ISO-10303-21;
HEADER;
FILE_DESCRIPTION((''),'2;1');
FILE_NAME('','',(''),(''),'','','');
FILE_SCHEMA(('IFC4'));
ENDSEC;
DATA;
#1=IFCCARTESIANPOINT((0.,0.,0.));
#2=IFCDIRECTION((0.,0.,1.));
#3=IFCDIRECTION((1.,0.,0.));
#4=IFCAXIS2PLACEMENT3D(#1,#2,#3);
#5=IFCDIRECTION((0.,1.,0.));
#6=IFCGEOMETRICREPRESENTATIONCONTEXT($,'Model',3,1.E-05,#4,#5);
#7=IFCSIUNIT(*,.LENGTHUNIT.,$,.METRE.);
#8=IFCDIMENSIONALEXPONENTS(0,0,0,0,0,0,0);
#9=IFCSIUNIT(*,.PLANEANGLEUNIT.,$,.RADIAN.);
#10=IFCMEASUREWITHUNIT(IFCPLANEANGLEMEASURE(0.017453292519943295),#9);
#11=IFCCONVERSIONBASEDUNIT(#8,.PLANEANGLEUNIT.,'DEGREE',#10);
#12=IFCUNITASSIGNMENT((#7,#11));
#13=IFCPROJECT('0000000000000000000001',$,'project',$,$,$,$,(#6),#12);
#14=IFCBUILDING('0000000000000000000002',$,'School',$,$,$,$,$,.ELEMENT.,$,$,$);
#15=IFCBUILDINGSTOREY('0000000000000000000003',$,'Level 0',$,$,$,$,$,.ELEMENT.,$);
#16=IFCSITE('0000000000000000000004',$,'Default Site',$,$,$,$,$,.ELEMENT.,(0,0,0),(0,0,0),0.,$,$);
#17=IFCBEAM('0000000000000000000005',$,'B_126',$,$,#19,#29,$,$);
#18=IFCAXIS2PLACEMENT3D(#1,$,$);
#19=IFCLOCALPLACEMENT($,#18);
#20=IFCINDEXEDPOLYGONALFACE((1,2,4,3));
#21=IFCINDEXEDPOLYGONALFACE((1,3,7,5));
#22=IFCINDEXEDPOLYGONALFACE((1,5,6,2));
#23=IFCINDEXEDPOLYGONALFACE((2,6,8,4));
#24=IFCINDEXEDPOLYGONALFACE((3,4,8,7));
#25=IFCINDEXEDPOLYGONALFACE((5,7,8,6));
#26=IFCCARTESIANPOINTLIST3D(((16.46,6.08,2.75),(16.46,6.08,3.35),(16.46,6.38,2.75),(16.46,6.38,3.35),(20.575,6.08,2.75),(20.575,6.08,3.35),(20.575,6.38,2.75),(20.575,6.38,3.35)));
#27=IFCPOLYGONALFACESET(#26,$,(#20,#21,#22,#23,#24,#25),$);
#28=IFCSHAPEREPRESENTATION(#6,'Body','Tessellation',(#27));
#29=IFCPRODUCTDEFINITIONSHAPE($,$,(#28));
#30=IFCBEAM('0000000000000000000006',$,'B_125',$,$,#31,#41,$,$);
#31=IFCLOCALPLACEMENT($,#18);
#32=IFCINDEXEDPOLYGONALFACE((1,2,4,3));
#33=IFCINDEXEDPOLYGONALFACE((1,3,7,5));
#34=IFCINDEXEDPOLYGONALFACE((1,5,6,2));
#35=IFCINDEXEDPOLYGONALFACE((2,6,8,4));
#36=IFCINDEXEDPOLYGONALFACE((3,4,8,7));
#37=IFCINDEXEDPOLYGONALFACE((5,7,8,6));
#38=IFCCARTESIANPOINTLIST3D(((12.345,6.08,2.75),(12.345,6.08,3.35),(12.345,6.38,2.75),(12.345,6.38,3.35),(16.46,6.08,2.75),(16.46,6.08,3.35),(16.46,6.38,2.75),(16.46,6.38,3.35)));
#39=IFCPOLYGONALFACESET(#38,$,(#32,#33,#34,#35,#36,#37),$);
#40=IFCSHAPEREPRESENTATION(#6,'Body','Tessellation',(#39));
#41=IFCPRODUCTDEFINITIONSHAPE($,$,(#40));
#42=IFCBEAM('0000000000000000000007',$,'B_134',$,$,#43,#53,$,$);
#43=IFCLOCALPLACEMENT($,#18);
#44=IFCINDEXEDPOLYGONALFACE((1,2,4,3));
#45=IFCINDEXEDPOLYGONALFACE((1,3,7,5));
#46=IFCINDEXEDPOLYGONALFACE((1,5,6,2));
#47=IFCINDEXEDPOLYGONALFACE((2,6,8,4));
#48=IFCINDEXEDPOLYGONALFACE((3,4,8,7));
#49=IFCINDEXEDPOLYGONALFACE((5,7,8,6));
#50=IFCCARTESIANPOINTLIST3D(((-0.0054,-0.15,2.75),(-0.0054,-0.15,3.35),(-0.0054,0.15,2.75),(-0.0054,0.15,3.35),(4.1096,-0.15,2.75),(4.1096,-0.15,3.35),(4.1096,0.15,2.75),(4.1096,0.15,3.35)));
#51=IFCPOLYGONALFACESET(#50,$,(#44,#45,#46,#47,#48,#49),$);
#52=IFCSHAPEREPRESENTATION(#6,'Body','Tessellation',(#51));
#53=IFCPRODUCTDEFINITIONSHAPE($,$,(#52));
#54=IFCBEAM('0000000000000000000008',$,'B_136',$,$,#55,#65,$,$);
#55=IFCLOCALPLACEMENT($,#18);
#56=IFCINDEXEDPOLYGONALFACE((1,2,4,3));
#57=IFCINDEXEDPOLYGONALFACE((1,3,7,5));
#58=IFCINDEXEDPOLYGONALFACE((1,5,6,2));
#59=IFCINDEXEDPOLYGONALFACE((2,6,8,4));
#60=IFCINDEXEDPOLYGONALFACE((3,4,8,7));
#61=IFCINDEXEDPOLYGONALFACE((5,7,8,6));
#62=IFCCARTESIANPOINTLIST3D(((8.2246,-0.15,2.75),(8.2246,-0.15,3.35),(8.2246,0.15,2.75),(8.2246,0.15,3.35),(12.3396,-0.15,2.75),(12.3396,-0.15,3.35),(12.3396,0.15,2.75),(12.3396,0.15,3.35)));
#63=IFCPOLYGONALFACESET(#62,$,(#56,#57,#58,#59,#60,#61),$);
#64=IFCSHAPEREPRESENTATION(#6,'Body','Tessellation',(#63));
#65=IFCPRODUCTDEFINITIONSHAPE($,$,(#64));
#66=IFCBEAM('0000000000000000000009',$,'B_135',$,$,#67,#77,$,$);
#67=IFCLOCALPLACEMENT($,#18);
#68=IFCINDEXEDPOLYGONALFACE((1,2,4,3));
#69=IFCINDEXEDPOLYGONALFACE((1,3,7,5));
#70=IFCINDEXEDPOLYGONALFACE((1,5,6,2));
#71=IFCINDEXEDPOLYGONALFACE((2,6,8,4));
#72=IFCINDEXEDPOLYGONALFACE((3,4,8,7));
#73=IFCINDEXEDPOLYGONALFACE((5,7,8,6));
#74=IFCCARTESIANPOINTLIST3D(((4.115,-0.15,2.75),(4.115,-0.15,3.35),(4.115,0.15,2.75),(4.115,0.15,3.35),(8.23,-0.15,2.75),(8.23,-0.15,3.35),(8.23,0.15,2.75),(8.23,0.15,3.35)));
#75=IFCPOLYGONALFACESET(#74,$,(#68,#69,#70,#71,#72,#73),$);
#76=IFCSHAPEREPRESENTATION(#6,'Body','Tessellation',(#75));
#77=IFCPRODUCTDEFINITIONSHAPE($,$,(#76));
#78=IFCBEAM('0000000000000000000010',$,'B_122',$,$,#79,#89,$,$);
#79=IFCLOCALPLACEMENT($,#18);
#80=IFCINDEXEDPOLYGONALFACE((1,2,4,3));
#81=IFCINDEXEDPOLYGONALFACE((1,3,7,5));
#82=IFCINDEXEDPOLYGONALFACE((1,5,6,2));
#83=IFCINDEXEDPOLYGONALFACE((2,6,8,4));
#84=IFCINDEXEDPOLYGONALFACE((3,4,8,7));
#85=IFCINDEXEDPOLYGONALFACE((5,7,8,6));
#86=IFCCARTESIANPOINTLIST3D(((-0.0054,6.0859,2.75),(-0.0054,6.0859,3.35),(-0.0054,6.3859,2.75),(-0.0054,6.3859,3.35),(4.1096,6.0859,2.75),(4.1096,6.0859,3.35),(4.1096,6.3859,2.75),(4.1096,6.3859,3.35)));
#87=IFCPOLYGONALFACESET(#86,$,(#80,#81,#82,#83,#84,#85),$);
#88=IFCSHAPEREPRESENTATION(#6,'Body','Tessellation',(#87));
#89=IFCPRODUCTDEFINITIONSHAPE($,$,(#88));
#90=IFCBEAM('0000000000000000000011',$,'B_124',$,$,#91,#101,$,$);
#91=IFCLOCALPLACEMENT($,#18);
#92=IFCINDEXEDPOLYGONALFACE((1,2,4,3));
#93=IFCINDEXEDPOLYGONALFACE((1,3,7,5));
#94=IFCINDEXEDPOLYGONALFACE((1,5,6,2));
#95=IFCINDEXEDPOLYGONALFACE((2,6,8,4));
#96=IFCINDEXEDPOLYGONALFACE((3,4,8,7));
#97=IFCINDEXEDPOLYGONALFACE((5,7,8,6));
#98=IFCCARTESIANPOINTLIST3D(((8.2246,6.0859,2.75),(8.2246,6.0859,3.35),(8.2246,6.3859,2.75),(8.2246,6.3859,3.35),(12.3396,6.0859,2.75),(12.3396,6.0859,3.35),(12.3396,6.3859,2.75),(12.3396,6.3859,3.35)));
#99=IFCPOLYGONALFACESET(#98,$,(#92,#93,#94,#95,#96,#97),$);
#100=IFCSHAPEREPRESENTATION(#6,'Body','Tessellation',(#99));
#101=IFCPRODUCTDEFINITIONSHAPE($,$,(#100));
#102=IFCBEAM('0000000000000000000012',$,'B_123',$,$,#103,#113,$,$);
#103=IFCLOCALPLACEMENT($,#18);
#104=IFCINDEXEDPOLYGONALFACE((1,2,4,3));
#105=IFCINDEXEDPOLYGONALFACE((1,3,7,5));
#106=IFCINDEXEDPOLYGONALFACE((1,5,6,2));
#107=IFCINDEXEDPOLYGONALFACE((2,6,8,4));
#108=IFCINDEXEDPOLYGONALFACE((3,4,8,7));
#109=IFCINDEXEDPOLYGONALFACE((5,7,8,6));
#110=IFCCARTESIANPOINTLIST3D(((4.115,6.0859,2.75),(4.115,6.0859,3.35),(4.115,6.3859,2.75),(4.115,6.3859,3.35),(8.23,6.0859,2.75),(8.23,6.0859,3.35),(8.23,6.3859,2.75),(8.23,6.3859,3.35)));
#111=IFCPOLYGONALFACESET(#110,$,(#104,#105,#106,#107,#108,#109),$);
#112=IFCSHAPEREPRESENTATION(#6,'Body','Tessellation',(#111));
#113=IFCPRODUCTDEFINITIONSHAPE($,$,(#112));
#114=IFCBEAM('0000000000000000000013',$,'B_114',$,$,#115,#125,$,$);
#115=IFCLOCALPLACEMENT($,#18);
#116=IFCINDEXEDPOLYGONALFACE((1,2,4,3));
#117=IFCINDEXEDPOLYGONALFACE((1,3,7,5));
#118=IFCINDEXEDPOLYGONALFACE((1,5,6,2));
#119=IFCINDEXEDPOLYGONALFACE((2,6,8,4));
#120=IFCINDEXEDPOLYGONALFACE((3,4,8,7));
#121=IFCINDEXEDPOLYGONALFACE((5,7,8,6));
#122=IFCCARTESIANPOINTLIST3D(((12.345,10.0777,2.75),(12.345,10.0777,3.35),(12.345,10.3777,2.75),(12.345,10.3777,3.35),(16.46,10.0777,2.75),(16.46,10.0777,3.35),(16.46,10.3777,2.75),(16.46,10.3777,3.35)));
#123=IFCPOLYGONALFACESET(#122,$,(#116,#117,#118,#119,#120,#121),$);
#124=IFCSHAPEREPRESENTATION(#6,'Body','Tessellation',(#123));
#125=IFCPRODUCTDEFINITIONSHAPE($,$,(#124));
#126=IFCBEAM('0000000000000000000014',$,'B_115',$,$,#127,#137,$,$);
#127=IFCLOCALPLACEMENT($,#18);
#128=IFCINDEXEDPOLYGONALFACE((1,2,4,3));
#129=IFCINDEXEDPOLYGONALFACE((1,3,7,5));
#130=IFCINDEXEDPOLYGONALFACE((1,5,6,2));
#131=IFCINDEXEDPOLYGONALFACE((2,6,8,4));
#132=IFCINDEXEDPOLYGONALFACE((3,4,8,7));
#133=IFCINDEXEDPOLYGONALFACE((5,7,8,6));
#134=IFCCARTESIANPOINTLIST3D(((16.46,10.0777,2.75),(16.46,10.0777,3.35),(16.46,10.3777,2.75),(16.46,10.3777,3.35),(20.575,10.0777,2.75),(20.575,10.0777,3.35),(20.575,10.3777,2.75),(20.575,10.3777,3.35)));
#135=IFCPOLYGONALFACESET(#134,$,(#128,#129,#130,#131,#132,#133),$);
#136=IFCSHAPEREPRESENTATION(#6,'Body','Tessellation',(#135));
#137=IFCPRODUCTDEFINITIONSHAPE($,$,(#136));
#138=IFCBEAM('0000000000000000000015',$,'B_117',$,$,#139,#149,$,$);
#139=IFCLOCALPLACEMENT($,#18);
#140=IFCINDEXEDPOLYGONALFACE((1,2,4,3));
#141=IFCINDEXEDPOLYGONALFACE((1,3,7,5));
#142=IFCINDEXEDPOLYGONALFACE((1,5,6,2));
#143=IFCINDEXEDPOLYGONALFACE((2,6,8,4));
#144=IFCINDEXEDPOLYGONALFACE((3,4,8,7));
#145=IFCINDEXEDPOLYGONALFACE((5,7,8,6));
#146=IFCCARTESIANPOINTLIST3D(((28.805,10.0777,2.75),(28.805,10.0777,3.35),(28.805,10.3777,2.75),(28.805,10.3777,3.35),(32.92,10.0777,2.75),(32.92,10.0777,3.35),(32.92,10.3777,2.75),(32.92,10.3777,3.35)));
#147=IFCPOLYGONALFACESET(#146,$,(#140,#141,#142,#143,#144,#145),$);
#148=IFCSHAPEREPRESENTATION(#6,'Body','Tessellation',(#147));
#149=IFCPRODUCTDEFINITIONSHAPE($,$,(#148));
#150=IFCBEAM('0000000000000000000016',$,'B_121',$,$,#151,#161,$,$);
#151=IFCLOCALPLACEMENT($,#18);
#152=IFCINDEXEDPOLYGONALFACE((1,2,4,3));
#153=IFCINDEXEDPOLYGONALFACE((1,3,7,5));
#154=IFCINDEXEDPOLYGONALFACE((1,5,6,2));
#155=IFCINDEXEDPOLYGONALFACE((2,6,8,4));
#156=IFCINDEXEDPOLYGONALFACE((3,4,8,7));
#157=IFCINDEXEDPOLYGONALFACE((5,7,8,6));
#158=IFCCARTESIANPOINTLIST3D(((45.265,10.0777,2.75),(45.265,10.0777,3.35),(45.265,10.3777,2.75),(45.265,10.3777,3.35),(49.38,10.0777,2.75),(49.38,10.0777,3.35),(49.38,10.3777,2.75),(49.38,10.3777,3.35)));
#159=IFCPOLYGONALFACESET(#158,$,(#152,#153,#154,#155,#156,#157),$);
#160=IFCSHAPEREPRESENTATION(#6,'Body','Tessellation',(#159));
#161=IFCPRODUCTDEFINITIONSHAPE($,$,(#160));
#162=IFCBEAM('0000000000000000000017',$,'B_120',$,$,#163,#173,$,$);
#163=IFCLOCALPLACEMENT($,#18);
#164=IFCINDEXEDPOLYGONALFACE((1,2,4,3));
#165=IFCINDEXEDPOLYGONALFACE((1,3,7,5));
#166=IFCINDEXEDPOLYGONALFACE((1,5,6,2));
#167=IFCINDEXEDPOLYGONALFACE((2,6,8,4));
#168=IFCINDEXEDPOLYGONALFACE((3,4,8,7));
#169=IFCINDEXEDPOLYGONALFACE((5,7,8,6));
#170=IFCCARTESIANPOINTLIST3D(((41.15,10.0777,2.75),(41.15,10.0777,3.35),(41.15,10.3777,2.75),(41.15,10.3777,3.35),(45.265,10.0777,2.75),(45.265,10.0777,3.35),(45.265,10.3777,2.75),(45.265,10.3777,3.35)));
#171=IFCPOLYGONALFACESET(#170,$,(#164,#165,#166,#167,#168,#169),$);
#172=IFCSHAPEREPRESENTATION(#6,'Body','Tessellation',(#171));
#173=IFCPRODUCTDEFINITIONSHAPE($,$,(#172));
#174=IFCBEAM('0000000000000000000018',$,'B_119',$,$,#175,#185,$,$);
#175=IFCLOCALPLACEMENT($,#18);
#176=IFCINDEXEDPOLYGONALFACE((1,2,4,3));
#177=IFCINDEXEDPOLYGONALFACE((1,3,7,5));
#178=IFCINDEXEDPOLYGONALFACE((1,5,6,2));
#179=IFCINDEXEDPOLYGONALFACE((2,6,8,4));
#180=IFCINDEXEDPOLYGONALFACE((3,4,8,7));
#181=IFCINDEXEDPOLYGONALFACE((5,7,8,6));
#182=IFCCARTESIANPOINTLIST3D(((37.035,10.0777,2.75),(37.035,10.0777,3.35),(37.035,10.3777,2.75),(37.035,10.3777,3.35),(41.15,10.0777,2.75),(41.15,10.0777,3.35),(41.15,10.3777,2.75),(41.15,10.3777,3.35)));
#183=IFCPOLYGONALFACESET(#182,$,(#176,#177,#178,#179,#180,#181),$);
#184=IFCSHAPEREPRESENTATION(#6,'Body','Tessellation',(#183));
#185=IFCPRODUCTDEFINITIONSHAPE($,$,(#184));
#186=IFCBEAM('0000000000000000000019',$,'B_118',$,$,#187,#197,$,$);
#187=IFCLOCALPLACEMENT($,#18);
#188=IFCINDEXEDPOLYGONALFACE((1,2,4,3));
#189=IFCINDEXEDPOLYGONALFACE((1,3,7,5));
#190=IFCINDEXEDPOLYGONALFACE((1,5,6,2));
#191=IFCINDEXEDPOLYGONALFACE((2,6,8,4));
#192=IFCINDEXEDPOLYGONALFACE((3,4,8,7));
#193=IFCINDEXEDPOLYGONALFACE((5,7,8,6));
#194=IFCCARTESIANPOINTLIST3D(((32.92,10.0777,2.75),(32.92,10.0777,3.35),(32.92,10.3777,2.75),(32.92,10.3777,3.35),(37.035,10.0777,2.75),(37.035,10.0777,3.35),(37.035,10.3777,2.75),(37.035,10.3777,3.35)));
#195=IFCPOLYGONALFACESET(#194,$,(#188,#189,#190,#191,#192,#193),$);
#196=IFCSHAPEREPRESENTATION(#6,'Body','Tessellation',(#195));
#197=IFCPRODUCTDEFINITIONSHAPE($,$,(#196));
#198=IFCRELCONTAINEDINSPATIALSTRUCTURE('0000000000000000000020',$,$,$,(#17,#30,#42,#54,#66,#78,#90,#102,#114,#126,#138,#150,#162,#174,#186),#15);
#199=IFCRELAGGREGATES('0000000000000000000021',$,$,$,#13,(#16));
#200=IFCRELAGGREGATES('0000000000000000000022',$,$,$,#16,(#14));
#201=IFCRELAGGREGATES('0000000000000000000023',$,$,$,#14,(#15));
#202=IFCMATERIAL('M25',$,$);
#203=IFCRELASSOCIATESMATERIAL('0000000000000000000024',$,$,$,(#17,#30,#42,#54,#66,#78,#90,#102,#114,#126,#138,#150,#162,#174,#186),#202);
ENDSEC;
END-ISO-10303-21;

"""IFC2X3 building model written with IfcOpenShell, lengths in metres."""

from ifc_helpers import new_model, entity, si_unit, converted_unit, direction, frame, frame_2d, origin_with_axes, place, context, project, spatial, rectangle, extrude, material, element, save


model = new_model("IFC2X3")

# Units and contexts
model_context = context("Model", 3, precision=1e-05, world=origin_with_axes(), true_north=direction((0.0, 1.0, 0.0)))
ifc_project = project(units=[si_unit("LENGTHUNIT", "METRE"), converted_unit("PLANEANGLEUNIT", "DEGREE", entity("IfcPlaneAngleMeasure", 0.017453292519943295), si_unit("PLANEANGLEUNIT", "RADIAN"), dimensions=[0, 0, 0, 0, 0, 0, 0])], contexts=[model_context])

# Site, building, storey
site = spatial("IfcSite", under=ifc_project, Name="Default Site", CompositionType="ELEMENT", RefLatitude=(0, 0, 0), RefLongitude=(0, 0, 0), RefElevation=0.0)
building = spatial("IfcBuilding", under=site, Name="School", CompositionType="ELEMENT")
storey = spatial("IfcBuildingStorey", under=building, Name="Level 0", CompositionType="ELEMENT")

# Beams
ifc_material = material(Name="M25")
placement = place(None, origin_with_axes())
element("IfcBeam", 1, at=placement, inside=storey, material=ifc_material, Name="B_126", context=model_context, shape_type="SweptSolid", body=[
    extrude(rectangle(XDim=0.3, YDim=0.6, at=frame_2d((0.0, 0.0), x_axis=(0.0, 1.0, 0.0))), frame((16.46, 6.23, 3.05), z_axis=(1.0, 0.0, 0.0), x_axis=(0.0, 0.0, -1.0)), (0.0, 0.0, 1.0), 4.115),
])
element("IfcBeam", 2, at=placement, inside=storey, material=ifc_material, Name="B_125", context=model_context, shape_type="SweptSolid", body=[
    extrude(rectangle(XDim=0.3, YDim=0.6, at=frame_2d((0.0, 0.0), x_axis=(0.0, 1.0, 0.0))), frame((12.345, 6.23, 3.05), z_axis=(1.0, 0.0, 0.0), x_axis=(0.0, 0.0, -1.0)), (0.0, 0.0, 1.0), 4.115),
])
element("IfcBeam", 3, at=placement, inside=storey, material=ifc_material, Name="B_134", context=model_context, shape_type="SweptSolid", body=[
    extrude(rectangle(XDim=0.3, YDim=0.6, at=frame_2d((0.0, 0.0), x_axis=(0.0, 1.0, 0.0))), frame((-0.0054, 0.0, 3.05), z_axis=(1.0, 0.0, 0.0), x_axis=(0.0, 0.0, -1.0)), (0.0, 0.0, 1.0), 4.115),
])
element("IfcBeam", 4, at=placement, inside=storey, material=ifc_material, Name="B_136", context=model_context, shape_type="SweptSolid", body=[
    extrude(rectangle(XDim=0.3, YDim=0.6, at=frame_2d((0.0, 0.0), x_axis=(0.0, 1.0, 0.0))), frame((8.2246, 0.0, 3.05), z_axis=(1.0, 0.0, 0.0), x_axis=(0.0, 0.0, -1.0)), (0.0, 0.0, 1.0), 4.115),
])
element("IfcBeam", 5, at=placement, inside=storey, material=ifc_material, Name="B_135", context=model_context, shape_type="SweptSolid", body=[
    extrude(rectangle(XDim=0.3, YDim=0.6, at=frame_2d((0.0, 0.0), x_axis=(0.0, 1.0, 0.0))), frame((4.115, 0.0, 3.05), z_axis=(1.0, 0.0, 0.0), x_axis=(0.0, 0.0, -1.0)), (0.0, 0.0, 1.0), 4.115),
])
element("IfcBeam", 6, at=placement, inside=storey, material=ifc_material, Name="B_122", context=model_context, shape_type="SweptSolid", body=[
    extrude(rectangle(XDim=0.3, YDim=0.6, at=frame_2d((0.0, 0.0), x_axis=(0.0, 1.0, 0.0))), frame((-0.0054, 6.2359, 3.05), z_axis=(1.0, 0.0, 0.0), x_axis=(0.0, 0.0, -1.0)), (0.0, 0.0, 1.0), 4.115),
])
element("IfcBeam", 7, at=placement, inside=storey, material=ifc_material, Name="B_124", context=model_context, shape_type="SweptSolid", body=[
    extrude(rectangle(XDim=0.3, YDim=0.6, at=frame_2d((0.0, 0.0), x_axis=(0.0, 1.0, 0.0))), frame((8.2246, 6.2359, 3.05), z_axis=(1.0, 0.0, 0.0), x_axis=(0.0, 0.0, -1.0)), (0.0, 0.0, 1.0), 4.115),
])
element("IfcBeam", 8, at=placement, inside=storey, material=ifc_material, Name="B_123", context=model_context, shape_type="SweptSolid", body=[
    extrude(rectangle(XDim=0.3, YDim=0.6, at=frame_2d((0.0, 0.0), x_axis=(0.0, 1.0, 0.0))), frame((4.115, 6.2359, 3.05), z_axis=(1.0, 0.0, 0.0), x_axis=(0.0, 0.0, -1.0)), (0.0, 0.0, 1.0), 4.115),
])
element("IfcBeam", 9, at=placement, inside=storey, material=ifc_material, Name="B_114", context=model_context, shape_type="SweptSolid", body=[
    extrude(rectangle(XDim=0.3, YDim=0.6, at=frame_2d((0.0, 0.0), x_axis=(0.0, 1.0, 0.0))), frame((12.345, 10.2277, 3.05), z_axis=(1.0, 0.0, 0.0), x_axis=(0.0, 0.0, -1.0)), (0.0, 0.0, 1.0), 4.115),
])
element("IfcBeam", 10, at=placement, inside=storey, material=ifc_material, Name="B_115", context=model_context, shape_type="SweptSolid", body=[
    extrude(rectangle(XDim=0.3, YDim=0.6, at=frame_2d((0.0, 0.0), x_axis=(0.0, 1.0, 0.0))), frame((16.46, 10.2277, 3.05), z_axis=(1.0, 0.0, 0.0), x_axis=(0.0, 0.0, -1.0)), (0.0, 0.0, 1.0), 4.115),
])
element("IfcBeam", 11, at=placement, inside=storey, material=ifc_material, Name="B_117", context=model_context, shape_type="SweptSolid", body=[
    extrude(rectangle(XDim=0.3, YDim=0.6, at=frame_2d((0.0, 0.0), x_axis=(0.0, 1.0, 0.0))), frame((28.805, 10.2277, 3.05), z_axis=(1.0, 0.0, 0.0), x_axis=(0.0, 0.0, -1.0)), (0.0, 0.0, 1.0), 4.115),
])
element("IfcBeam", 12, at=placement, inside=storey, material=ifc_material, Name="B_121", context=model_context, shape_type="SweptSolid", body=[
    extrude(rectangle(XDim=0.3, YDim=0.6, at=frame_2d((0.0, 0.0), x_axis=(0.0, 1.0, 0.0))), frame((45.265, 10.2277, 3.05), z_axis=(1.0, 0.0, 0.0), x_axis=(0.0, 0.0, -1.0)), (0.0, 0.0, 1.0), 4.115),
])
element("IfcBeam", 13, at=placement, inside=storey, material=ifc_material, Name="B_120", context=model_context, shape_type="SweptSolid", body=[
    extrude(rectangle(XDim=0.3, YDim=0.6, at=frame_2d((0.0, 0.0), x_axis=(0.0, 1.0, 0.0))), frame((41.15, 10.2277, 3.05), z_axis=(1.0, 0.0, 0.0), x_axis=(0.0, 0.0, -1.0)), (0.0, 0.0, 1.0), 4.115),
])
element("IfcBeam", 14, at=placement, inside=storey, material=ifc_material, Name="B_119", context=model_context, shape_type="SweptSolid", body=[
    extrude(rectangle(XDim=0.3, YDim=0.6, at=frame_2d((0.0, 0.0), x_axis=(0.0, 1.0, 0.0))), frame((37.035, 10.2277, 3.05), z_axis=(1.0, 0.0, 0.0), x_axis=(0.0, 0.0, -1.0)), (0.0, 0.0, 1.0), 4.115),
])
element("IfcBeam", 15, at=placement, inside=storey, material=ifc_material, Name="B_118", context=model_context, shape_type="SweptSolid", body=[
    extrude(rectangle(XDim=0.3, YDim=0.6, at=frame_2d((0.0, 0.0), x_axis=(0.0, 1.0, 0.0))), frame((32.92, 10.2277, 3.05), z_axis=(1.0, 0.0, 0.0), x_axis=(0.0, 0.0, -1.0)), (0.0, 0.0, 1.0), 4.115),
])

save(model, "model.ifc")
